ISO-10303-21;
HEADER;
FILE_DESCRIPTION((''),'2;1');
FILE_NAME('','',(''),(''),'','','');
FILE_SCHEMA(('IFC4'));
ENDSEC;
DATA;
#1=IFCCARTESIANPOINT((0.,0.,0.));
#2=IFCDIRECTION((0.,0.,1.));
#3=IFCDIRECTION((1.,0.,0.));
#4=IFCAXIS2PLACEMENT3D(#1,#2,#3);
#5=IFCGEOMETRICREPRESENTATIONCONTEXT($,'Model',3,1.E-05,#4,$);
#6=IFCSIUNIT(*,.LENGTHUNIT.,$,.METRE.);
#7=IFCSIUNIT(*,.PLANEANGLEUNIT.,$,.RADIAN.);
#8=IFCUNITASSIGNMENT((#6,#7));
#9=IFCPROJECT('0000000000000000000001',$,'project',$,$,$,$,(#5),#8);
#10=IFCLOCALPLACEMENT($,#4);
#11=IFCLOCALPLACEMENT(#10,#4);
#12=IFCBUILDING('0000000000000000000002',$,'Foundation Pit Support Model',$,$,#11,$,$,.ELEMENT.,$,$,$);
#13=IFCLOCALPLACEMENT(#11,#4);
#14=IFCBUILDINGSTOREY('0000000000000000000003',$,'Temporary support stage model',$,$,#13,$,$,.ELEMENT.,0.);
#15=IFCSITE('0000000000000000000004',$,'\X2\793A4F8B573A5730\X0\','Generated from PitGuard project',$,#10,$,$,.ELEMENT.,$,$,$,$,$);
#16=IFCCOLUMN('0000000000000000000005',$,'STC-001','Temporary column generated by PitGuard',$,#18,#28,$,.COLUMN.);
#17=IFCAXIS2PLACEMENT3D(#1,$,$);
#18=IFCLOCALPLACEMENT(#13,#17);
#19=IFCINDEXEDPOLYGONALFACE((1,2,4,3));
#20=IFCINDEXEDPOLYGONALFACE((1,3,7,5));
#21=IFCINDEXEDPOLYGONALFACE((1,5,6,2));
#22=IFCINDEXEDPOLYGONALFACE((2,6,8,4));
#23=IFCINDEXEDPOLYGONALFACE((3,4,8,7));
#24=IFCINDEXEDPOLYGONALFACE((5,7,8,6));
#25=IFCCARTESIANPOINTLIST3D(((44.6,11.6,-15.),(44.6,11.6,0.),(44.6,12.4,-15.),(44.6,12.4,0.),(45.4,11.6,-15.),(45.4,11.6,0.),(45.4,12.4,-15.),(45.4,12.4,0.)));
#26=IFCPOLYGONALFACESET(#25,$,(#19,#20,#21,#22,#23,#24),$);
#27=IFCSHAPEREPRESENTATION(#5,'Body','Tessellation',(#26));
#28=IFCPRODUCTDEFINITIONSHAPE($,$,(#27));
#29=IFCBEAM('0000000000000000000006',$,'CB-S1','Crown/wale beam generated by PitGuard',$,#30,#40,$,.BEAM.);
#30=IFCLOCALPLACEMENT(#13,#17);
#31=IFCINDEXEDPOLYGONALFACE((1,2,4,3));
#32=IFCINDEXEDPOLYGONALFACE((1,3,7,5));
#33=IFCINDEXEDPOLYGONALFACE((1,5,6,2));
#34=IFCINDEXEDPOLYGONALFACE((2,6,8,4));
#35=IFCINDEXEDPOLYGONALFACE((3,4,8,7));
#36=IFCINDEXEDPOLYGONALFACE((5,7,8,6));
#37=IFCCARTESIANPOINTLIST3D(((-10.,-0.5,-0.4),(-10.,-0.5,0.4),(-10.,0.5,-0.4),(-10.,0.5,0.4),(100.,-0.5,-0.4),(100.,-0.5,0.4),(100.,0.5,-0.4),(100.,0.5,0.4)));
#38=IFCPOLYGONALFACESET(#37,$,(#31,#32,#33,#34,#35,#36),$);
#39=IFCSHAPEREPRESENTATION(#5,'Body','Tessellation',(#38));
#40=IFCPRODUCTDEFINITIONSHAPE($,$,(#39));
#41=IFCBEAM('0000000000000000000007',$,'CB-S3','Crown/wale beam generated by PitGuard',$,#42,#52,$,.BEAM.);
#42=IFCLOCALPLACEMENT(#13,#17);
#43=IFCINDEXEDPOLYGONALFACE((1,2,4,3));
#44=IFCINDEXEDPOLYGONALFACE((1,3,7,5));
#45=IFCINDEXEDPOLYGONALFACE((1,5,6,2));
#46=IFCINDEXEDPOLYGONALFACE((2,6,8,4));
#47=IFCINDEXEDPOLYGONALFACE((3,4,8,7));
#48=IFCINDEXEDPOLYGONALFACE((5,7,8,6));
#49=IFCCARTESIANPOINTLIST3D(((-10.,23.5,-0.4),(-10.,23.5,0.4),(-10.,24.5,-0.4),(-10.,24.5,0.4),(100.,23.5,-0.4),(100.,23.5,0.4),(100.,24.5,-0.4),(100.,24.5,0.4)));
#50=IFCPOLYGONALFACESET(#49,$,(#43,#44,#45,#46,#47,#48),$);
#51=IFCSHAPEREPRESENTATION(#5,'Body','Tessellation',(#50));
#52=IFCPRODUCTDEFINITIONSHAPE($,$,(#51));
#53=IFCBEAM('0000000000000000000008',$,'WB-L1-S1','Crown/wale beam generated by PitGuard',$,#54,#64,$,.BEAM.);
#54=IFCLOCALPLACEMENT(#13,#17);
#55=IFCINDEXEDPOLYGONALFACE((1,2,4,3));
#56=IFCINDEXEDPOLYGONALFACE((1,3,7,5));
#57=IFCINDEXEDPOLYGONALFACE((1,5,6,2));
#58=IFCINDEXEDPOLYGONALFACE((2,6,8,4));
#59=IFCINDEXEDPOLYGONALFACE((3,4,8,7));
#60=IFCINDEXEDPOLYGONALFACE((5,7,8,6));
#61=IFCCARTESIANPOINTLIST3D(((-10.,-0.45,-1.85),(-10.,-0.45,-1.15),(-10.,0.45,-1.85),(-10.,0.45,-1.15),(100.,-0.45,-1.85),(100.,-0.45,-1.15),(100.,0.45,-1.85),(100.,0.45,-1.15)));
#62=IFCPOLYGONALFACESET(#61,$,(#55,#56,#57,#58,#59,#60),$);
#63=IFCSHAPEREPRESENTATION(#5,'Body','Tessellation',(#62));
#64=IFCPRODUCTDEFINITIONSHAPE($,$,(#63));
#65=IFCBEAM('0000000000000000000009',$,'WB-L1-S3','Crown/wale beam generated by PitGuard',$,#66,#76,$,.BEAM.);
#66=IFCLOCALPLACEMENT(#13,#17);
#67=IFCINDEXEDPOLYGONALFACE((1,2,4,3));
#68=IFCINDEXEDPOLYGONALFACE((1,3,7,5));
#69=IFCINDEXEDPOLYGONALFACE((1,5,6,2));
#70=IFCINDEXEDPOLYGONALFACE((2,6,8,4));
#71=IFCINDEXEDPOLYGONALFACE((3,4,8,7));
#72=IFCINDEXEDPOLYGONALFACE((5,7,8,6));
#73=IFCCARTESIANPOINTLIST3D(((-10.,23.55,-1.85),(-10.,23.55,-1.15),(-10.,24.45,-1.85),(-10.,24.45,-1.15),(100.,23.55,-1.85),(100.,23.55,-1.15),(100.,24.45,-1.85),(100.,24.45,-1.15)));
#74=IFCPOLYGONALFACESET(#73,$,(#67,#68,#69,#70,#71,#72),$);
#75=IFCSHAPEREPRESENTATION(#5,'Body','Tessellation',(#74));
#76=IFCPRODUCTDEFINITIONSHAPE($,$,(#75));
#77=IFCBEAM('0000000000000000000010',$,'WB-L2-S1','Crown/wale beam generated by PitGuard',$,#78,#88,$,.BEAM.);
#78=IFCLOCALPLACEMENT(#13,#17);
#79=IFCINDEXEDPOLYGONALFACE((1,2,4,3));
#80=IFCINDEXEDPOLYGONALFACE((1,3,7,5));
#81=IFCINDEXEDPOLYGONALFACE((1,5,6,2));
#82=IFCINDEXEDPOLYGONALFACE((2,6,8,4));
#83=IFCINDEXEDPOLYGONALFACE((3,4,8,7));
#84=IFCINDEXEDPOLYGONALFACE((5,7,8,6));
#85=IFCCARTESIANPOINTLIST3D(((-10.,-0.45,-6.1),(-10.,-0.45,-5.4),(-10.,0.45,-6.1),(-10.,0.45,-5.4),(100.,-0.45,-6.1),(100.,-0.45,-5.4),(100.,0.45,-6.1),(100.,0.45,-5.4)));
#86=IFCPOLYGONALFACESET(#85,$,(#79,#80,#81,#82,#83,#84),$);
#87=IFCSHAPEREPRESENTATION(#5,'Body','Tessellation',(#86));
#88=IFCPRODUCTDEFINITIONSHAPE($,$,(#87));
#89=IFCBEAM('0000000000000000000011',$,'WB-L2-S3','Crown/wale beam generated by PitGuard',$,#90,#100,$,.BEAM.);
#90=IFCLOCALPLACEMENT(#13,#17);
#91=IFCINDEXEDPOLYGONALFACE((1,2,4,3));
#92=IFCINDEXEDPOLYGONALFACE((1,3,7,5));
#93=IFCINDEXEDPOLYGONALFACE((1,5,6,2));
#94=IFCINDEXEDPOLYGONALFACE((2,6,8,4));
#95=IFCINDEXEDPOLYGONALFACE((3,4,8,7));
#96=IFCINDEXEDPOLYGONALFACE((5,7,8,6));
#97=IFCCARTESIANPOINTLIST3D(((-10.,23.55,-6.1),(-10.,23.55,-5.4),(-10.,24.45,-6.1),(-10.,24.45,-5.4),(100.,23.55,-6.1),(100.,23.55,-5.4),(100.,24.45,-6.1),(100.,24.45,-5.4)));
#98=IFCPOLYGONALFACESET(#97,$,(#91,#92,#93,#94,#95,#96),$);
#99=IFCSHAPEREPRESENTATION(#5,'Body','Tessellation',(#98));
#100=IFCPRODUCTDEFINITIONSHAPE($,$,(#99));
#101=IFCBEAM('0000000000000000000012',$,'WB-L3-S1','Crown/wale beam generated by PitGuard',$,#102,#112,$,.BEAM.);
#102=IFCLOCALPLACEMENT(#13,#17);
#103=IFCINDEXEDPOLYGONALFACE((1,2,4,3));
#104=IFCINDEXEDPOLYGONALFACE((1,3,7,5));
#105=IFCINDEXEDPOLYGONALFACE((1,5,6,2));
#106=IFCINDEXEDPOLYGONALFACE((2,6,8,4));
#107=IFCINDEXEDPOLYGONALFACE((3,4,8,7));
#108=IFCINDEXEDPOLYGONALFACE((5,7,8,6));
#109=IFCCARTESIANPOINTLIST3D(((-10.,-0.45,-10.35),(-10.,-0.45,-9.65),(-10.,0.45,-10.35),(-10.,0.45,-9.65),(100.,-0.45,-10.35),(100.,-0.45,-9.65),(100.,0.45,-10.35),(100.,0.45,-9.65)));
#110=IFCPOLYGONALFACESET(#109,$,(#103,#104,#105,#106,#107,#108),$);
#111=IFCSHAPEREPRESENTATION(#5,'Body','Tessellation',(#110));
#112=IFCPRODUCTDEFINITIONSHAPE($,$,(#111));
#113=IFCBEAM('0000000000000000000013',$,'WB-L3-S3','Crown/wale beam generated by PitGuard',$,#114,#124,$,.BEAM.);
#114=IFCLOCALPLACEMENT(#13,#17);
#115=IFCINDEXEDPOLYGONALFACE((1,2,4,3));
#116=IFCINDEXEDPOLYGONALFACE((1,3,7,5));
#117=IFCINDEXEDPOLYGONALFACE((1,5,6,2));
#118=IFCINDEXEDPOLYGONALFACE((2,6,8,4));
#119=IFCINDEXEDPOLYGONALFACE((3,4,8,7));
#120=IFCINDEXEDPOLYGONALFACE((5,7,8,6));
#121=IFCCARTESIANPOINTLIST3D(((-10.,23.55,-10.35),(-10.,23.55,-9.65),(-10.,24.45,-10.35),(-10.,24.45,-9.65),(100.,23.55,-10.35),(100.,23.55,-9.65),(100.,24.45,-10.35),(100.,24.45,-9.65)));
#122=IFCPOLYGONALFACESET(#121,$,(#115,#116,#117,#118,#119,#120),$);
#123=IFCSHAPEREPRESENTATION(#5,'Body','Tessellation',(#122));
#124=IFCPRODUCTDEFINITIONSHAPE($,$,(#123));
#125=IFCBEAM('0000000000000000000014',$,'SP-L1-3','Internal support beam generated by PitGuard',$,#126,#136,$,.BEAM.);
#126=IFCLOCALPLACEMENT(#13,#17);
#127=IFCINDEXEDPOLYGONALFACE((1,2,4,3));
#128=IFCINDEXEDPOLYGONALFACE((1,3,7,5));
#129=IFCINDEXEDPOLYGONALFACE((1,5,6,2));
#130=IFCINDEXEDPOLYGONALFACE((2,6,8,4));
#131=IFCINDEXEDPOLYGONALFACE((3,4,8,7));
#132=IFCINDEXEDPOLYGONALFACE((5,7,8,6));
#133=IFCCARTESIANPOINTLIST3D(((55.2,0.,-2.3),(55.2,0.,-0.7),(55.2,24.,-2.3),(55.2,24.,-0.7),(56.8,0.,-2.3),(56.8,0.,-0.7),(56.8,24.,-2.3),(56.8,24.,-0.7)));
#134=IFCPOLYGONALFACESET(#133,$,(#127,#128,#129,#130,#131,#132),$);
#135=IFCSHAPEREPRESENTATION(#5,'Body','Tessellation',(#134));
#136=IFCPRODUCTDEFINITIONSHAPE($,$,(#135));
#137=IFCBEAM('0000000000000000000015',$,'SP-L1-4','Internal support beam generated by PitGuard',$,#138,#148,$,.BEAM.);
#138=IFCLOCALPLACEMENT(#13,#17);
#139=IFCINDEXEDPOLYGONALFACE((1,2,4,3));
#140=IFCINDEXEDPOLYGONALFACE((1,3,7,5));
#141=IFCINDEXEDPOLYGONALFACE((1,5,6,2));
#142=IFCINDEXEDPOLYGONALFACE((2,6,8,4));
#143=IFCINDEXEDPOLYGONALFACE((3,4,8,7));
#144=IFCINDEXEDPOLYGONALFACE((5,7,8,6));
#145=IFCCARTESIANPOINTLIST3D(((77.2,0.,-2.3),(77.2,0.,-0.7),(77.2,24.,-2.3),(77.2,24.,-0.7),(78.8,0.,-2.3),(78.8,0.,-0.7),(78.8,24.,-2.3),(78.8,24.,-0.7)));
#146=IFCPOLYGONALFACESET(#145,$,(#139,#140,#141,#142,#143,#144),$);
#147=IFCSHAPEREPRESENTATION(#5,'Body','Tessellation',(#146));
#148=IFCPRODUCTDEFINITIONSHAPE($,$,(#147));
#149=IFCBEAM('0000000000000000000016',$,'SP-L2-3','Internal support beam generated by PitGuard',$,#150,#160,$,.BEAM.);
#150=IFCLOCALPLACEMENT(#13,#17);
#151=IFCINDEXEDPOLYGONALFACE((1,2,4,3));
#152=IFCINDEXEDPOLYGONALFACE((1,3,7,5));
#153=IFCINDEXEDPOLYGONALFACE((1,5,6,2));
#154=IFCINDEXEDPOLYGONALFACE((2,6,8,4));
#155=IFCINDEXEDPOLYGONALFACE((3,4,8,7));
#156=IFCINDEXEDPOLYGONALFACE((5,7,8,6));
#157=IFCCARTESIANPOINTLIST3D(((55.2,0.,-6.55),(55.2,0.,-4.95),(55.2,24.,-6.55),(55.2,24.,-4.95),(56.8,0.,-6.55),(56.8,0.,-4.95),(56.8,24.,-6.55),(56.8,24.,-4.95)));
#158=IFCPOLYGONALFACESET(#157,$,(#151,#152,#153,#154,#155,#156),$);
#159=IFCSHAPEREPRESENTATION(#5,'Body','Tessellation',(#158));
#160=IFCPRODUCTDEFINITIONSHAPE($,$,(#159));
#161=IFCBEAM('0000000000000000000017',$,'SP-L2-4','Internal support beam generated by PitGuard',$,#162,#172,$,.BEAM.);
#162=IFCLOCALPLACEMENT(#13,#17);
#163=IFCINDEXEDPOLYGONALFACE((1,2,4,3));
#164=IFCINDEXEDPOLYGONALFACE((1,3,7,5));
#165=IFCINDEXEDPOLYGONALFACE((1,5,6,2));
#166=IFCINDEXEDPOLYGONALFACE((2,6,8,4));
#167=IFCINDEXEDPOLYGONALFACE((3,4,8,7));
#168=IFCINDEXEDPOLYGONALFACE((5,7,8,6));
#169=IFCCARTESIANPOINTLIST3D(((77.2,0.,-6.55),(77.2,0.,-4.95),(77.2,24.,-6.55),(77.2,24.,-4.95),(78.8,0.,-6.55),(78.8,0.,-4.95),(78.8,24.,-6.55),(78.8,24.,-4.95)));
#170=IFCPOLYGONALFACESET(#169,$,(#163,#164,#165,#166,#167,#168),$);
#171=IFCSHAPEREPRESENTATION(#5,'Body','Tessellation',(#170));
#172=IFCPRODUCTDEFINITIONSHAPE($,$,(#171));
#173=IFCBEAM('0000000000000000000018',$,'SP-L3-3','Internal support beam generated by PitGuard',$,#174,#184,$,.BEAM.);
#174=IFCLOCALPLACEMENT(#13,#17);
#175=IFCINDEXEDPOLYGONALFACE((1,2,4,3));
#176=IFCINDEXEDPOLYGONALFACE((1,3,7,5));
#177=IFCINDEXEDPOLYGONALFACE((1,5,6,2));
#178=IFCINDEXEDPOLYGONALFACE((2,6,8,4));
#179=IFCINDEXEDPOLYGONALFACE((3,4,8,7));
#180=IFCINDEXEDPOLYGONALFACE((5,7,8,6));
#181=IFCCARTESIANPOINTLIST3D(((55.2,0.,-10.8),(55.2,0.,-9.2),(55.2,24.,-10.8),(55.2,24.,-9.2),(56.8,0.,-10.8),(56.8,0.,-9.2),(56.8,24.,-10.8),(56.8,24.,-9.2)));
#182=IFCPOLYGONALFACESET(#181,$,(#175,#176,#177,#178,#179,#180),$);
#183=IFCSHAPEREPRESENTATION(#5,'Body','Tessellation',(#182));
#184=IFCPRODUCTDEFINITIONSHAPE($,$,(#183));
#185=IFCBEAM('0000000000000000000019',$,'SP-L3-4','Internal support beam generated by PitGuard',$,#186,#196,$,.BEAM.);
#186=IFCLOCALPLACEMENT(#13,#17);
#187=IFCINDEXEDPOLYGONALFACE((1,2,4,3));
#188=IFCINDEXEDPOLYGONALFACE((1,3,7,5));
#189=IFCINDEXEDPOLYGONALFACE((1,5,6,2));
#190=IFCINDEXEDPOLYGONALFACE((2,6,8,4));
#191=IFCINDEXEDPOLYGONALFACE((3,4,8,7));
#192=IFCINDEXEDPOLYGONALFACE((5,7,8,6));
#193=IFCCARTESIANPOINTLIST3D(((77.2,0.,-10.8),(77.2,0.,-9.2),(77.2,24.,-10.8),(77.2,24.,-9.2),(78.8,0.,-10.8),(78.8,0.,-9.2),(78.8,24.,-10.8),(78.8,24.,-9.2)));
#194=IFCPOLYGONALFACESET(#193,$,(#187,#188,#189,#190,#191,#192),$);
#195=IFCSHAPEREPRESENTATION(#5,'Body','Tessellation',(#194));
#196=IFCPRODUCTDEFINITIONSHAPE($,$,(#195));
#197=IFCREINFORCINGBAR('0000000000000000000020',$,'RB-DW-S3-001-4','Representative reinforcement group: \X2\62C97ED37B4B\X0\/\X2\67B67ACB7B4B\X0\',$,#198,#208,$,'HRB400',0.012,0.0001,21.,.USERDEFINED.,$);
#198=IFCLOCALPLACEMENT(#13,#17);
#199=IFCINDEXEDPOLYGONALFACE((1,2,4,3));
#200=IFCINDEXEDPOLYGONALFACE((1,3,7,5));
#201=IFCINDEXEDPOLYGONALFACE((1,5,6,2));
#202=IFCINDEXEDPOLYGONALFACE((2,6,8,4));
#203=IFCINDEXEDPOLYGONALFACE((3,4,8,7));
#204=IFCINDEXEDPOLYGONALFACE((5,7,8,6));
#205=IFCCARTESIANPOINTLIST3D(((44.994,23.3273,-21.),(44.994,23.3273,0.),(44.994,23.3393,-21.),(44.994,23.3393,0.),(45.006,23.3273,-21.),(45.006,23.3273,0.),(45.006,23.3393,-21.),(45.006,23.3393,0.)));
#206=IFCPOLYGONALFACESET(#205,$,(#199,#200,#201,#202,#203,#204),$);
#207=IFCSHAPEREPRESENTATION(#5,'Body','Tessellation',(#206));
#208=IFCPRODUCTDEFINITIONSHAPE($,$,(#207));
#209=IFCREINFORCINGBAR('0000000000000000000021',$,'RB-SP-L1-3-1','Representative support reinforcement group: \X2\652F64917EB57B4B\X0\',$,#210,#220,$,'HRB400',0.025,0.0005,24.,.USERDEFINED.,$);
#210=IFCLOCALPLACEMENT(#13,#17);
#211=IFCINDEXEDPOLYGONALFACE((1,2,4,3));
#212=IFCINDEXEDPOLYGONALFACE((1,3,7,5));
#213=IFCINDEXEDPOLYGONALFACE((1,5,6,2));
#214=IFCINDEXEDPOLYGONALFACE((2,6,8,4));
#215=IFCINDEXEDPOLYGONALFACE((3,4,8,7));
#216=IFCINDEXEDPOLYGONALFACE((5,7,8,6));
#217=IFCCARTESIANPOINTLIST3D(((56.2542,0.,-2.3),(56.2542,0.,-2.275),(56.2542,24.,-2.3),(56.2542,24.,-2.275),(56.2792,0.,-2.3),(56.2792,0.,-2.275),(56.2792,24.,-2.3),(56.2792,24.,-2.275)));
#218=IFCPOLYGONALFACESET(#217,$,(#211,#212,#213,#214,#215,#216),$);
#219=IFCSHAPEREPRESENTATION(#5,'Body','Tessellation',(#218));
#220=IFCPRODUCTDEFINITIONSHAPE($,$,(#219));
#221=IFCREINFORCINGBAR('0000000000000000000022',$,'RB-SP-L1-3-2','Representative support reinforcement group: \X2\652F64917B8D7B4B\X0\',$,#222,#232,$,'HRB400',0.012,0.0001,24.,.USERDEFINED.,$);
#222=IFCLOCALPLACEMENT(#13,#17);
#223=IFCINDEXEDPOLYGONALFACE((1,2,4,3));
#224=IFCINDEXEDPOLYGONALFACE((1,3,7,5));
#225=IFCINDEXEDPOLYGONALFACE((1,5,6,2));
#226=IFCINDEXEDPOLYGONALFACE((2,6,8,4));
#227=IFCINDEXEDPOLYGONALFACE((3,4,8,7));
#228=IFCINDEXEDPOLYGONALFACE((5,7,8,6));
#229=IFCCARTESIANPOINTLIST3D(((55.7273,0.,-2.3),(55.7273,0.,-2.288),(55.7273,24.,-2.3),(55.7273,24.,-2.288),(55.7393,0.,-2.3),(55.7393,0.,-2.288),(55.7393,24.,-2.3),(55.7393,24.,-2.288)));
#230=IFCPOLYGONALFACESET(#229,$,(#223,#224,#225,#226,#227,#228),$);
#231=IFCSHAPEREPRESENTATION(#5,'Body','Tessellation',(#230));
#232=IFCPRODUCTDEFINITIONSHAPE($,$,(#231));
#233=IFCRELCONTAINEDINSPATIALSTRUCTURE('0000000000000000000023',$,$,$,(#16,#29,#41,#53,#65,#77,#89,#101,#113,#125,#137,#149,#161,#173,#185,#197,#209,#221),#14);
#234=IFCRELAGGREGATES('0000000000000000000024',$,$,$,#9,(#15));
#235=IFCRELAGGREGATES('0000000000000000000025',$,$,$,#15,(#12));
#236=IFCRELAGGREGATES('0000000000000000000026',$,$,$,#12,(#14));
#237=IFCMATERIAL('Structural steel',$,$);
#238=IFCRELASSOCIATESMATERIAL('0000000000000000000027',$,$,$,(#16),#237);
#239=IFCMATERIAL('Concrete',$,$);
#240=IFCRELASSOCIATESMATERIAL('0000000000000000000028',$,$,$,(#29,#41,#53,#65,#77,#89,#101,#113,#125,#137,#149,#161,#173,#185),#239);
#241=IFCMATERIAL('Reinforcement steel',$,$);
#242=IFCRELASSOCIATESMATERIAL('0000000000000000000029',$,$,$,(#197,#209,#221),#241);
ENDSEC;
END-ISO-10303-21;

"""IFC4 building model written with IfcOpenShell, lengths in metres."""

from ifc_helpers import new_model, si_unit, frame, origin_with_axes, origin_2d, place, context, project, spatial, rectangle, extrude, material, element, save


model = new_model("IFC4")

# Units and contexts
model_context = context("Model", 3, precision=1e-05, world=origin_with_axes())
ifc_project = project(units=[si_unit("LENGTHUNIT", "METRE"), si_unit("PLANEANGLEUNIT", "RADIAN")], contexts=[model_context])

# Site, building, storey
site_placement = place(None, origin_with_axes())
site = spatial("IfcSite", under=ifc_project, at=site_placement, Name="示例场地", Description="Generated from PitGuard project", CompositionType="ELEMENT")
building_placement = place(site_placement, origin_with_axes())
building = spatial("IfcBuilding", under=site, at=building_placement, Name="Foundation Pit Support Model", CompositionType="ELEMENT")
storey_placement = place(building_placement, origin_with_axes())
storey = spatial("IfcBuildingStorey", under=building, at=storey_placement, Name="Temporary support stage model", CompositionType="ELEMENT", Elevation=0.0)

# Column
ifc_material_1 = material(Name="Structural steel")
column_placement = place(storey_placement, frame((45.0, 12.0, -15.0), z_axis=(0.0, 0.0, 1.0), x_axis=(1.0, 0.0, 0.0)))
element("IfcColumn", 1, at=column_placement, inside=storey, material=ifc_material_1, Name="STC-001", Description="Temporary column generated by PitGuard", PredefinedType="COLUMN", context=model_context, shape_type="SweptSolid", body=[
    extrude(rectangle(XDim=0.8, YDim=0.8, at=origin_2d()), origin_with_axes(), (0.0, 0.0, 1.0), 15.0),
])

# Beams
ifc_material_2 = material(Name="Concrete")
for number, where, z_axis, x_axis, name in (
    (2, (45.0, 0.0, -0.4), (0.0, 0.0, 1.0), (1.0, 0.0, 0.0), "CB-S1"),
    (3, (45.0, 24.0, -0.4), (0.0, 0.0, 1.0), (-1.0, 0.0, 0.0), "CB-S3"),
):
    element("IfcBeam", number, at=place(storey_placement, frame(where, z_axis=z_axis, x_axis=x_axis)), inside=storey, material=ifc_material_2, Name=name, Description="Crown/wale beam generated by PitGuard", PredefinedType="BEAM", context=model_context, shape_type="SweptSolid", body=[
        extrude(rectangle(XDim=110.0, YDim=1.0, at=origin_2d()), origin_with_axes(), (0.0, 0.0, 1.0), 0.8),
    ])
for number, where, z_axis, x_axis, name in (
    (4, (45.0, 0.0, -1.85), (0.0, 0.0, 1.0), (1.0, 0.0, 0.0), "WB-L1-S1"),
    (5, (45.0, 24.0, -1.85), (0.0, 0.0, 1.0), (-1.0, 0.0, 0.0), "WB-L1-S3"),
    (6, (45.0, 0.0, -6.1), (0.0, 0.0, 1.0), (1.0, 0.0, 0.0), "WB-L2-S1"),
    (7, (45.0, 24.0, -6.1), (0.0, 0.0, 1.0), (-1.0, 0.0, 0.0), "WB-L2-S3"),
    (8, (45.0, 0.0, -10.35), (0.0, 0.0, 1.0), (1.0, 0.0, 0.0), "WB-L3-S1"),
    (9, (45.0, 24.0, -10.35), (0.0, 0.0, 1.0), (-1.0, 0.0, 0.0), "WB-L3-S3"),
):
    element("IfcBeam", number, at=place(storey_placement, frame(where, z_axis=z_axis, x_axis=x_axis)), inside=storey, material=ifc_material_2, Name=name, Description="Crown/wale beam generated by PitGuard", PredefinedType="BEAM", context=model_context, shape_type="SweptSolid", body=[
        extrude(rectangle(XDim=110.0, YDim=0.9, at=origin_2d()), origin_with_axes(), (0.0, 0.0, 1.0), 0.7),
    ])
for number, where, z_axis, x_axis, name in (
    (10, (56.0, 12.0, -2.3), (0.0, 0.0, 1.0), (0.0, 1.0, 0.0), "SP-L1-3"),
    (11, (78.0, 12.0, -2.3), (0.0, 0.0, 1.0), (0.0, 1.0, 0.0), "SP-L1-4"),
    (12, (56.0, 12.0, -6.55), (0.0, 0.0, 1.0), (0.0, 1.0, 0.0), "SP-L2-3"),
    (13, (78.0, 12.0, -6.55), (0.0, 0.0, 1.0), (0.0, 1.0, 0.0), "SP-L2-4"),
    (14, (56.0, 12.0, -10.8), (0.0, 0.0, 1.0), (0.0, 1.0, 0.0), "SP-L3-3"),
    (15, (78.0, 12.0, -10.8), (0.0, 0.0, 1.0), (0.0, 1.0, 0.0), "SP-L3-4"),
):
    element("IfcBeam", number, at=place(storey_placement, frame(where, z_axis=z_axis, x_axis=x_axis)), inside=storey, material=ifc_material_2, Name=name, Description="Internal support beam generated by PitGuard", PredefinedType="BEAM", context=model_context, shape_type="SweptSolid", body=[
        extrude(rectangle(XDim=24.0, YDim=1.6, at=origin_2d()), origin_with_axes(), (0.0, 0.0, 1.0), 1.6),
    ])

# Reinforcing bars
ifc_material_3 = material(Name="Reinforcement steel")
reinforcing_bar_1_placement = place(storey_placement, frame((45.0, 23.3333, -21.0), z_axis=(0.0, 0.0, 1.0), x_axis=(1.0, 0.0, 0.0)))
element("IfcReinforcingBar", 16, at=reinforcing_bar_1_placement, inside=storey, material=ifc_material_3, Name="RB-DW-S3-001-4", Description="Representative reinforcement group: 拉结筋/架立筋", SteelGrade="HRB400", BarLength=21.0, CrossSectionArea=0.0001, NominalDiameter=0.012, PredefinedType="USERDEFINED", context=model_context, shape_type="SweptSolid", body=[
    extrude(rectangle(XDim=0.012, YDim=0.012, at=origin_2d()), origin_with_axes(), (0.0, 0.0, 1.0), 21.0),
])
reinforcing_bar_2_placement = place(storey_placement, frame((56.2667, 12.0, -2.3), z_axis=(0.0, 0.0, 1.0), x_axis=(0.0, 1.0, 0.0)))
element("IfcReinforcingBar", 17, at=reinforcing_bar_2_placement, inside=storey, material=ifc_material_3, Name="RB-SP-L1-3-1", Description="Representative support reinforcement group: 支撑纵筋", SteelGrade="HRB400", BarLength=24.0, CrossSectionArea=0.0005, NominalDiameter=0.025, PredefinedType="USERDEFINED", context=model_context, shape_type="SweptSolid", body=[
    extrude(rectangle(XDim=24.0, YDim=0.025, at=origin_2d()), origin_with_axes(), (0.0, 0.0, 1.0), 0.025),
])
reinforcing_bar_3_placement = place(storey_placement, frame((55.7333, 12.0, -2.3), z_axis=(0.0, 0.0, 1.0), x_axis=(0.0, 1.0, 0.0)))
element("IfcReinforcingBar", 18, at=reinforcing_bar_3_placement, inside=storey, material=ifc_material_3, Name="RB-SP-L1-3-2", Description="Representative support reinforcement group: 支撑箍筋", SteelGrade="HRB400", BarLength=24.0, CrossSectionArea=0.0001, NominalDiameter=0.012, PredefinedType="USERDEFINED", context=model_context, shape_type="SweptSolid", body=[
    extrude(rectangle(XDim=24.0, YDim=0.012, at=origin_2d()), origin_with_axes(), (0.0, 0.0, 1.0), 0.012),
])

save(model, "model.ifc")
